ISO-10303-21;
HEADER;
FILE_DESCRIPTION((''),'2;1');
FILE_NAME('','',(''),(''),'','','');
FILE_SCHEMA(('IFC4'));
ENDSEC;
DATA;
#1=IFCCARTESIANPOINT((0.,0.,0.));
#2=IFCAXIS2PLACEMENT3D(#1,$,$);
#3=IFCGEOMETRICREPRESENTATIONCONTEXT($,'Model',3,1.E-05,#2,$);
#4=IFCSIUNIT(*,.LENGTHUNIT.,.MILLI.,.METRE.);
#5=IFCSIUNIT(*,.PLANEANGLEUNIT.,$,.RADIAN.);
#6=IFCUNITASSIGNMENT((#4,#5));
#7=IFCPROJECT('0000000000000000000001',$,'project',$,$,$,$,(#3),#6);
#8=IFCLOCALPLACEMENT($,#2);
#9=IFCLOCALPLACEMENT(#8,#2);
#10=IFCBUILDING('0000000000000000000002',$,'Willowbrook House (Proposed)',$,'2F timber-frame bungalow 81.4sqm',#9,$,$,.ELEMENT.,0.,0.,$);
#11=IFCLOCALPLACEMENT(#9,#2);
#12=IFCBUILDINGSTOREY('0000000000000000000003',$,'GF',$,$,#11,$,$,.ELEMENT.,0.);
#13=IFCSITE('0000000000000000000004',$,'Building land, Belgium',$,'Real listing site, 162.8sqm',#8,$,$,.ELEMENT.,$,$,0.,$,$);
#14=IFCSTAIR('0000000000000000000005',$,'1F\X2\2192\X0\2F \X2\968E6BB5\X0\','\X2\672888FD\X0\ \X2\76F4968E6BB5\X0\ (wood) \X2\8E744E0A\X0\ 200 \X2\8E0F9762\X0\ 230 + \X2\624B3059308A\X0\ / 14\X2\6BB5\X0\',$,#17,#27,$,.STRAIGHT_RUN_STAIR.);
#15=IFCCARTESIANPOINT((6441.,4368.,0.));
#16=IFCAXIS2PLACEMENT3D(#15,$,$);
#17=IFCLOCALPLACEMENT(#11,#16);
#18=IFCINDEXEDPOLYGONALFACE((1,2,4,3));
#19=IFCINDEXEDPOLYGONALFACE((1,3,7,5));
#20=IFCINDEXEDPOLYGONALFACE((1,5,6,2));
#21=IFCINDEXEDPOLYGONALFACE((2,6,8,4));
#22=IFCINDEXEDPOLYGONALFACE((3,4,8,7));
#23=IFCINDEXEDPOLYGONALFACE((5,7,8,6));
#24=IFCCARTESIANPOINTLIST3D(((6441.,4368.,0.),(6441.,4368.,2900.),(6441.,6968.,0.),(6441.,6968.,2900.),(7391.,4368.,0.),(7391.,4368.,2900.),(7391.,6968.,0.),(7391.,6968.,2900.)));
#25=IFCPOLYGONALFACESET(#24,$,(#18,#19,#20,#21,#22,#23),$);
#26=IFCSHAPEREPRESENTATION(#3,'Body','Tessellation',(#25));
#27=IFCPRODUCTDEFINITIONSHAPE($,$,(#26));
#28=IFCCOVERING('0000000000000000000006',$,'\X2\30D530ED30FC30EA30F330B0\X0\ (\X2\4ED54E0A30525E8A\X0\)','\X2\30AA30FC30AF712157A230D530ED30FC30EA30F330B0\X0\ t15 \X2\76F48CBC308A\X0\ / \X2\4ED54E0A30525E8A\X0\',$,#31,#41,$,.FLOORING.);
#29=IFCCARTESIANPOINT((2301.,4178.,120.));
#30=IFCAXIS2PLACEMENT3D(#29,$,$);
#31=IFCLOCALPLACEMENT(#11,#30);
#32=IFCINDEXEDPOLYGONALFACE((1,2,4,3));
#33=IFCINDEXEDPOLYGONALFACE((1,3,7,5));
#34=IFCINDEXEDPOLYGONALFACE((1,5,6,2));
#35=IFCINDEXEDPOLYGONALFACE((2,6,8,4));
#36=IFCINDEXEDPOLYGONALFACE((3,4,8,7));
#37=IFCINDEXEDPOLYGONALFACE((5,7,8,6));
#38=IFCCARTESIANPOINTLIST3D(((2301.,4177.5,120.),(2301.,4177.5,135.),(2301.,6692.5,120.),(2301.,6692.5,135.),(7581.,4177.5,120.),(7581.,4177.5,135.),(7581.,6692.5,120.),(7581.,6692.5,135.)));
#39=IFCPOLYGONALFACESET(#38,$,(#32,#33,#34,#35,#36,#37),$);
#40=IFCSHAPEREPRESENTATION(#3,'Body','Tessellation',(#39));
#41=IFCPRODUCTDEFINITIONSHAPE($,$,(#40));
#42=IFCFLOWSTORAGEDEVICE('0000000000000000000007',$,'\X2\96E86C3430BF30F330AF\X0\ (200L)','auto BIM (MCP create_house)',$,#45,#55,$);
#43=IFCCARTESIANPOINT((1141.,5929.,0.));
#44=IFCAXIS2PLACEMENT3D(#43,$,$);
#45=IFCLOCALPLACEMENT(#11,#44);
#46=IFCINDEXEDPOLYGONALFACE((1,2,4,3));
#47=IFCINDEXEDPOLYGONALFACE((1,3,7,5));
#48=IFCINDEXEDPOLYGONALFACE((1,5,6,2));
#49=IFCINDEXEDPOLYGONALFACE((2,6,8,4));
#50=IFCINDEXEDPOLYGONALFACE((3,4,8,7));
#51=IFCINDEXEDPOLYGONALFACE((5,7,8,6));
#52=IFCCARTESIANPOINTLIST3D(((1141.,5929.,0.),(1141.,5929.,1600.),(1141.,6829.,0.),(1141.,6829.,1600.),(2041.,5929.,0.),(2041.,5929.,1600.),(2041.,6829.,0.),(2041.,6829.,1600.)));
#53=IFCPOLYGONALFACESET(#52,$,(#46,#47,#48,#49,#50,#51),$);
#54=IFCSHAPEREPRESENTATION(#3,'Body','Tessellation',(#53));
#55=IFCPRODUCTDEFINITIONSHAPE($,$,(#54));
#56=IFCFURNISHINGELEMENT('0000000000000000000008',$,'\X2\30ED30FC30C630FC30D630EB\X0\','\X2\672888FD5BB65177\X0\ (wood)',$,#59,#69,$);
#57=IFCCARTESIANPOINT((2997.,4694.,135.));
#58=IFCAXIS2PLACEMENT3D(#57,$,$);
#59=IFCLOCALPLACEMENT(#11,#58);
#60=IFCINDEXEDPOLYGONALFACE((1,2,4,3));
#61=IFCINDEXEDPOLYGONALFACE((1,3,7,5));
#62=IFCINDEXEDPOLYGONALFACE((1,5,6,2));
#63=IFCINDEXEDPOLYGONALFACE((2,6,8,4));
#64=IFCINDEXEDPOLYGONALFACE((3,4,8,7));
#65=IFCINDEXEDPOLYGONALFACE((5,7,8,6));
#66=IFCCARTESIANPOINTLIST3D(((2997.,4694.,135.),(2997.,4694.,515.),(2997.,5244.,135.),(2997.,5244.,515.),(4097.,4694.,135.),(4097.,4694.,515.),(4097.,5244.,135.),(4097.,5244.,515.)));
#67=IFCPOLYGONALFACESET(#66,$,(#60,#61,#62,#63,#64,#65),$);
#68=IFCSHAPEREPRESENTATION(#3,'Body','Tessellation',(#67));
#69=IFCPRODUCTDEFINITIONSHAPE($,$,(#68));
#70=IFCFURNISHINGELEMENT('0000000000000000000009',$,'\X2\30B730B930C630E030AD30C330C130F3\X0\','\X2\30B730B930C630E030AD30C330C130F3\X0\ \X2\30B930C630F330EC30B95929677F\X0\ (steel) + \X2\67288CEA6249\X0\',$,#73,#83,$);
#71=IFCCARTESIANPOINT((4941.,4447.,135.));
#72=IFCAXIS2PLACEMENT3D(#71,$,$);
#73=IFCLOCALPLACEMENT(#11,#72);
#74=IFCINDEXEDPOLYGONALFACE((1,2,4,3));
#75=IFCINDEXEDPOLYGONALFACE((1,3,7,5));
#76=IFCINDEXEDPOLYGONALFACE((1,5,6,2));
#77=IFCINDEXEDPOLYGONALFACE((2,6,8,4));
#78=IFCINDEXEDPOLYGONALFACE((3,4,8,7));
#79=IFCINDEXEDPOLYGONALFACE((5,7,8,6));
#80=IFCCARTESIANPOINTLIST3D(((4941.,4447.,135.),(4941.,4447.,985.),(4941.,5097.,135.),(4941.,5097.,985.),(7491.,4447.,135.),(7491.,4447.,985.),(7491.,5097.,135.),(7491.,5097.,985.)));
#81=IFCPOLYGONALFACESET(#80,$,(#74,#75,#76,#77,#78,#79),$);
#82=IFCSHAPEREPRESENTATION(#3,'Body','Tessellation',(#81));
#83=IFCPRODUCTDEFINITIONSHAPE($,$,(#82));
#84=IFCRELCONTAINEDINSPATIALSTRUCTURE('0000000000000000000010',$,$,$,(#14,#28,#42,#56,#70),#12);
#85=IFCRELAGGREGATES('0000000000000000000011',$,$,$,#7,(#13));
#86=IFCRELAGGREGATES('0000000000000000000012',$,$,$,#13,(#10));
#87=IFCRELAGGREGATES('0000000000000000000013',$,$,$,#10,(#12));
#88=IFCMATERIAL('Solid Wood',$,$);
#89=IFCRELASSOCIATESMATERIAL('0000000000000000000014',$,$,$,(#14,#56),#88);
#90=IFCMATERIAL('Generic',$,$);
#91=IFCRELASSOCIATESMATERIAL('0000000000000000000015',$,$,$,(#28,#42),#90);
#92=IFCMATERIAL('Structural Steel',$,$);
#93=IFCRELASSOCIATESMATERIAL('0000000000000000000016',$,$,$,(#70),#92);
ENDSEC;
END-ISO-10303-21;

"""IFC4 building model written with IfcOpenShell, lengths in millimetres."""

from ifc_helpers import new_model, si_unit, frame, frame_2d, origin, place, context, project, spatial, rectangle, extrude, material, element, save


model = new_model("IFC4")

# Units and contexts
model_context = context("Model", 3, precision=1e-05, world=origin())
ifc_project = project(units=[si_unit("LENGTHUNIT", "METRE", prefix="MILLI"), si_unit("PLANEANGLEUNIT", "RADIAN")], contexts=[model_context])

# Site, building, storey
site_placement = place(None, origin())
site = spatial("IfcSite", under=ifc_project, at=site_placement, Name="Building land, Belgium", ObjectType="Real listing site, 162.8sqm", CompositionType="ELEMENT", RefElevation=0.0)
building_placement = place(site_placement, origin())
building = spatial("IfcBuilding", under=site, at=building_placement, Name="Willowbrook House (Proposed)", ObjectType="2F timber-frame bungalow 81.4sqm", CompositionType="ELEMENT", ElevationOfRefHeight=0.0, ElevationOfTerrain=0.0)
storey_placement = place(building_placement, origin())
storey = spatial("IfcBuildingStorey", under=building, at=storey_placement, Name="GF", CompositionType="ELEMENT", Elevation=0.0)

# Shared definitions
ifc_material_1 = material(Name="Solid Wood")

# Stair
stair_placement = place(storey_placement, frame((6441.0, 4368.0, 0.0)))
element("IfcStair", 1, at=stair_placement, inside=storey, material=ifc_material_1, Name="1F→2F 階段", Description="木製 直階段 (wood) 蹴上 200 踏面 230 + 手すり / 14段", PredefinedType="STRAIGHT_RUN_STAIR", context=model_context, shape_type="SweptSolid", body=[
    extrude(rectangle(XDim=950.0, YDim=2600.0, at=frame_2d((475.0, 1300.0))), frame((6441.0, 4368.0, 0.0)), (0.0, 0.0, 1.0), 2900.0),
])

# Covering
ifc_material_2 = material(Name="Generic")
covering_placement = place(storey_placement, frame((2301.0, 4178.0, 120.0)))
element("IfcCovering", 2, at=covering_placement, inside=storey, material=ifc_material_2, Name="フローリング (仕上げ床)", Description="オーク無垢フローリング t15 直貼り / 仕上げ床", PredefinedType="FLOORING", context=model_context, shape_type="SweptSolid", body=[
    extrude(rectangle(XDim=5280.0, YDim=2515.0, at=frame_2d((2640.0, 1257.0))), frame((2301.0, 4178.0, 120.0)), (0.0, 0.0, 1.0), 15.0),
])

# Flow storage device
flow_storage_device_placement = place(storey_placement, frame((1141.0, 5929.0, 0.0)))
element("IfcFlowStorageDevice", 3, at=flow_storage_device_placement, inside=storey, material=ifc_material_2, Name="雨水タンク (200L)", Description="auto BIM (MCP create_house)", context=model_context, shape_type="SweptSolid", body=[
    extrude(rectangle(XDim=900.0, YDim=900.0, at=frame_2d((450.0, 450.0))), frame((1141.0, 5929.0, 0.0)), (0.0, 0.0, 1.0), 1600.0),
])

# Furnishing elements
furnishing_1_placement = place(storey_placement, frame((2997.0, 4694.0, 135.0)))
element("IfcFurnishingElement", 4, at=furnishing_1_placement, inside=storey, material=ifc_material_1, Name="ローテーブル", Description="木製家具 (wood)", context=model_context, shape_type="SweptSolid", body=[
    extrude(rectangle(XDim=1100.0, YDim=550.0, at=frame_2d((550.0, 275.0))), frame((2997.0, 4694.0, 135.0)), (0.0, 0.0, 1.0), 380.0),
])
ifc_material_3 = material(Name="Structural Steel")
furnishing_2_placement = place(storey_placement, frame((4941.0, 4447.0, 135.0)))
element("IfcFurnishingElement", 5, at=furnishing_2_placement, inside=storey, material=ifc_material_3, Name="システムキッチン", Description="システムキッチン ステンレス天板 (steel) + 木質扉", context=model_context, shape_type="SweptSolid", body=[
    extrude(rectangle(XDim=2550.0, YDim=650.0, at=frame_2d((1275.0, 325.0))), frame((4941.0, 4447.0, 135.0)), (0.0, 0.0, 1.0), 850.0),
])

save(model, "model.ifc")
